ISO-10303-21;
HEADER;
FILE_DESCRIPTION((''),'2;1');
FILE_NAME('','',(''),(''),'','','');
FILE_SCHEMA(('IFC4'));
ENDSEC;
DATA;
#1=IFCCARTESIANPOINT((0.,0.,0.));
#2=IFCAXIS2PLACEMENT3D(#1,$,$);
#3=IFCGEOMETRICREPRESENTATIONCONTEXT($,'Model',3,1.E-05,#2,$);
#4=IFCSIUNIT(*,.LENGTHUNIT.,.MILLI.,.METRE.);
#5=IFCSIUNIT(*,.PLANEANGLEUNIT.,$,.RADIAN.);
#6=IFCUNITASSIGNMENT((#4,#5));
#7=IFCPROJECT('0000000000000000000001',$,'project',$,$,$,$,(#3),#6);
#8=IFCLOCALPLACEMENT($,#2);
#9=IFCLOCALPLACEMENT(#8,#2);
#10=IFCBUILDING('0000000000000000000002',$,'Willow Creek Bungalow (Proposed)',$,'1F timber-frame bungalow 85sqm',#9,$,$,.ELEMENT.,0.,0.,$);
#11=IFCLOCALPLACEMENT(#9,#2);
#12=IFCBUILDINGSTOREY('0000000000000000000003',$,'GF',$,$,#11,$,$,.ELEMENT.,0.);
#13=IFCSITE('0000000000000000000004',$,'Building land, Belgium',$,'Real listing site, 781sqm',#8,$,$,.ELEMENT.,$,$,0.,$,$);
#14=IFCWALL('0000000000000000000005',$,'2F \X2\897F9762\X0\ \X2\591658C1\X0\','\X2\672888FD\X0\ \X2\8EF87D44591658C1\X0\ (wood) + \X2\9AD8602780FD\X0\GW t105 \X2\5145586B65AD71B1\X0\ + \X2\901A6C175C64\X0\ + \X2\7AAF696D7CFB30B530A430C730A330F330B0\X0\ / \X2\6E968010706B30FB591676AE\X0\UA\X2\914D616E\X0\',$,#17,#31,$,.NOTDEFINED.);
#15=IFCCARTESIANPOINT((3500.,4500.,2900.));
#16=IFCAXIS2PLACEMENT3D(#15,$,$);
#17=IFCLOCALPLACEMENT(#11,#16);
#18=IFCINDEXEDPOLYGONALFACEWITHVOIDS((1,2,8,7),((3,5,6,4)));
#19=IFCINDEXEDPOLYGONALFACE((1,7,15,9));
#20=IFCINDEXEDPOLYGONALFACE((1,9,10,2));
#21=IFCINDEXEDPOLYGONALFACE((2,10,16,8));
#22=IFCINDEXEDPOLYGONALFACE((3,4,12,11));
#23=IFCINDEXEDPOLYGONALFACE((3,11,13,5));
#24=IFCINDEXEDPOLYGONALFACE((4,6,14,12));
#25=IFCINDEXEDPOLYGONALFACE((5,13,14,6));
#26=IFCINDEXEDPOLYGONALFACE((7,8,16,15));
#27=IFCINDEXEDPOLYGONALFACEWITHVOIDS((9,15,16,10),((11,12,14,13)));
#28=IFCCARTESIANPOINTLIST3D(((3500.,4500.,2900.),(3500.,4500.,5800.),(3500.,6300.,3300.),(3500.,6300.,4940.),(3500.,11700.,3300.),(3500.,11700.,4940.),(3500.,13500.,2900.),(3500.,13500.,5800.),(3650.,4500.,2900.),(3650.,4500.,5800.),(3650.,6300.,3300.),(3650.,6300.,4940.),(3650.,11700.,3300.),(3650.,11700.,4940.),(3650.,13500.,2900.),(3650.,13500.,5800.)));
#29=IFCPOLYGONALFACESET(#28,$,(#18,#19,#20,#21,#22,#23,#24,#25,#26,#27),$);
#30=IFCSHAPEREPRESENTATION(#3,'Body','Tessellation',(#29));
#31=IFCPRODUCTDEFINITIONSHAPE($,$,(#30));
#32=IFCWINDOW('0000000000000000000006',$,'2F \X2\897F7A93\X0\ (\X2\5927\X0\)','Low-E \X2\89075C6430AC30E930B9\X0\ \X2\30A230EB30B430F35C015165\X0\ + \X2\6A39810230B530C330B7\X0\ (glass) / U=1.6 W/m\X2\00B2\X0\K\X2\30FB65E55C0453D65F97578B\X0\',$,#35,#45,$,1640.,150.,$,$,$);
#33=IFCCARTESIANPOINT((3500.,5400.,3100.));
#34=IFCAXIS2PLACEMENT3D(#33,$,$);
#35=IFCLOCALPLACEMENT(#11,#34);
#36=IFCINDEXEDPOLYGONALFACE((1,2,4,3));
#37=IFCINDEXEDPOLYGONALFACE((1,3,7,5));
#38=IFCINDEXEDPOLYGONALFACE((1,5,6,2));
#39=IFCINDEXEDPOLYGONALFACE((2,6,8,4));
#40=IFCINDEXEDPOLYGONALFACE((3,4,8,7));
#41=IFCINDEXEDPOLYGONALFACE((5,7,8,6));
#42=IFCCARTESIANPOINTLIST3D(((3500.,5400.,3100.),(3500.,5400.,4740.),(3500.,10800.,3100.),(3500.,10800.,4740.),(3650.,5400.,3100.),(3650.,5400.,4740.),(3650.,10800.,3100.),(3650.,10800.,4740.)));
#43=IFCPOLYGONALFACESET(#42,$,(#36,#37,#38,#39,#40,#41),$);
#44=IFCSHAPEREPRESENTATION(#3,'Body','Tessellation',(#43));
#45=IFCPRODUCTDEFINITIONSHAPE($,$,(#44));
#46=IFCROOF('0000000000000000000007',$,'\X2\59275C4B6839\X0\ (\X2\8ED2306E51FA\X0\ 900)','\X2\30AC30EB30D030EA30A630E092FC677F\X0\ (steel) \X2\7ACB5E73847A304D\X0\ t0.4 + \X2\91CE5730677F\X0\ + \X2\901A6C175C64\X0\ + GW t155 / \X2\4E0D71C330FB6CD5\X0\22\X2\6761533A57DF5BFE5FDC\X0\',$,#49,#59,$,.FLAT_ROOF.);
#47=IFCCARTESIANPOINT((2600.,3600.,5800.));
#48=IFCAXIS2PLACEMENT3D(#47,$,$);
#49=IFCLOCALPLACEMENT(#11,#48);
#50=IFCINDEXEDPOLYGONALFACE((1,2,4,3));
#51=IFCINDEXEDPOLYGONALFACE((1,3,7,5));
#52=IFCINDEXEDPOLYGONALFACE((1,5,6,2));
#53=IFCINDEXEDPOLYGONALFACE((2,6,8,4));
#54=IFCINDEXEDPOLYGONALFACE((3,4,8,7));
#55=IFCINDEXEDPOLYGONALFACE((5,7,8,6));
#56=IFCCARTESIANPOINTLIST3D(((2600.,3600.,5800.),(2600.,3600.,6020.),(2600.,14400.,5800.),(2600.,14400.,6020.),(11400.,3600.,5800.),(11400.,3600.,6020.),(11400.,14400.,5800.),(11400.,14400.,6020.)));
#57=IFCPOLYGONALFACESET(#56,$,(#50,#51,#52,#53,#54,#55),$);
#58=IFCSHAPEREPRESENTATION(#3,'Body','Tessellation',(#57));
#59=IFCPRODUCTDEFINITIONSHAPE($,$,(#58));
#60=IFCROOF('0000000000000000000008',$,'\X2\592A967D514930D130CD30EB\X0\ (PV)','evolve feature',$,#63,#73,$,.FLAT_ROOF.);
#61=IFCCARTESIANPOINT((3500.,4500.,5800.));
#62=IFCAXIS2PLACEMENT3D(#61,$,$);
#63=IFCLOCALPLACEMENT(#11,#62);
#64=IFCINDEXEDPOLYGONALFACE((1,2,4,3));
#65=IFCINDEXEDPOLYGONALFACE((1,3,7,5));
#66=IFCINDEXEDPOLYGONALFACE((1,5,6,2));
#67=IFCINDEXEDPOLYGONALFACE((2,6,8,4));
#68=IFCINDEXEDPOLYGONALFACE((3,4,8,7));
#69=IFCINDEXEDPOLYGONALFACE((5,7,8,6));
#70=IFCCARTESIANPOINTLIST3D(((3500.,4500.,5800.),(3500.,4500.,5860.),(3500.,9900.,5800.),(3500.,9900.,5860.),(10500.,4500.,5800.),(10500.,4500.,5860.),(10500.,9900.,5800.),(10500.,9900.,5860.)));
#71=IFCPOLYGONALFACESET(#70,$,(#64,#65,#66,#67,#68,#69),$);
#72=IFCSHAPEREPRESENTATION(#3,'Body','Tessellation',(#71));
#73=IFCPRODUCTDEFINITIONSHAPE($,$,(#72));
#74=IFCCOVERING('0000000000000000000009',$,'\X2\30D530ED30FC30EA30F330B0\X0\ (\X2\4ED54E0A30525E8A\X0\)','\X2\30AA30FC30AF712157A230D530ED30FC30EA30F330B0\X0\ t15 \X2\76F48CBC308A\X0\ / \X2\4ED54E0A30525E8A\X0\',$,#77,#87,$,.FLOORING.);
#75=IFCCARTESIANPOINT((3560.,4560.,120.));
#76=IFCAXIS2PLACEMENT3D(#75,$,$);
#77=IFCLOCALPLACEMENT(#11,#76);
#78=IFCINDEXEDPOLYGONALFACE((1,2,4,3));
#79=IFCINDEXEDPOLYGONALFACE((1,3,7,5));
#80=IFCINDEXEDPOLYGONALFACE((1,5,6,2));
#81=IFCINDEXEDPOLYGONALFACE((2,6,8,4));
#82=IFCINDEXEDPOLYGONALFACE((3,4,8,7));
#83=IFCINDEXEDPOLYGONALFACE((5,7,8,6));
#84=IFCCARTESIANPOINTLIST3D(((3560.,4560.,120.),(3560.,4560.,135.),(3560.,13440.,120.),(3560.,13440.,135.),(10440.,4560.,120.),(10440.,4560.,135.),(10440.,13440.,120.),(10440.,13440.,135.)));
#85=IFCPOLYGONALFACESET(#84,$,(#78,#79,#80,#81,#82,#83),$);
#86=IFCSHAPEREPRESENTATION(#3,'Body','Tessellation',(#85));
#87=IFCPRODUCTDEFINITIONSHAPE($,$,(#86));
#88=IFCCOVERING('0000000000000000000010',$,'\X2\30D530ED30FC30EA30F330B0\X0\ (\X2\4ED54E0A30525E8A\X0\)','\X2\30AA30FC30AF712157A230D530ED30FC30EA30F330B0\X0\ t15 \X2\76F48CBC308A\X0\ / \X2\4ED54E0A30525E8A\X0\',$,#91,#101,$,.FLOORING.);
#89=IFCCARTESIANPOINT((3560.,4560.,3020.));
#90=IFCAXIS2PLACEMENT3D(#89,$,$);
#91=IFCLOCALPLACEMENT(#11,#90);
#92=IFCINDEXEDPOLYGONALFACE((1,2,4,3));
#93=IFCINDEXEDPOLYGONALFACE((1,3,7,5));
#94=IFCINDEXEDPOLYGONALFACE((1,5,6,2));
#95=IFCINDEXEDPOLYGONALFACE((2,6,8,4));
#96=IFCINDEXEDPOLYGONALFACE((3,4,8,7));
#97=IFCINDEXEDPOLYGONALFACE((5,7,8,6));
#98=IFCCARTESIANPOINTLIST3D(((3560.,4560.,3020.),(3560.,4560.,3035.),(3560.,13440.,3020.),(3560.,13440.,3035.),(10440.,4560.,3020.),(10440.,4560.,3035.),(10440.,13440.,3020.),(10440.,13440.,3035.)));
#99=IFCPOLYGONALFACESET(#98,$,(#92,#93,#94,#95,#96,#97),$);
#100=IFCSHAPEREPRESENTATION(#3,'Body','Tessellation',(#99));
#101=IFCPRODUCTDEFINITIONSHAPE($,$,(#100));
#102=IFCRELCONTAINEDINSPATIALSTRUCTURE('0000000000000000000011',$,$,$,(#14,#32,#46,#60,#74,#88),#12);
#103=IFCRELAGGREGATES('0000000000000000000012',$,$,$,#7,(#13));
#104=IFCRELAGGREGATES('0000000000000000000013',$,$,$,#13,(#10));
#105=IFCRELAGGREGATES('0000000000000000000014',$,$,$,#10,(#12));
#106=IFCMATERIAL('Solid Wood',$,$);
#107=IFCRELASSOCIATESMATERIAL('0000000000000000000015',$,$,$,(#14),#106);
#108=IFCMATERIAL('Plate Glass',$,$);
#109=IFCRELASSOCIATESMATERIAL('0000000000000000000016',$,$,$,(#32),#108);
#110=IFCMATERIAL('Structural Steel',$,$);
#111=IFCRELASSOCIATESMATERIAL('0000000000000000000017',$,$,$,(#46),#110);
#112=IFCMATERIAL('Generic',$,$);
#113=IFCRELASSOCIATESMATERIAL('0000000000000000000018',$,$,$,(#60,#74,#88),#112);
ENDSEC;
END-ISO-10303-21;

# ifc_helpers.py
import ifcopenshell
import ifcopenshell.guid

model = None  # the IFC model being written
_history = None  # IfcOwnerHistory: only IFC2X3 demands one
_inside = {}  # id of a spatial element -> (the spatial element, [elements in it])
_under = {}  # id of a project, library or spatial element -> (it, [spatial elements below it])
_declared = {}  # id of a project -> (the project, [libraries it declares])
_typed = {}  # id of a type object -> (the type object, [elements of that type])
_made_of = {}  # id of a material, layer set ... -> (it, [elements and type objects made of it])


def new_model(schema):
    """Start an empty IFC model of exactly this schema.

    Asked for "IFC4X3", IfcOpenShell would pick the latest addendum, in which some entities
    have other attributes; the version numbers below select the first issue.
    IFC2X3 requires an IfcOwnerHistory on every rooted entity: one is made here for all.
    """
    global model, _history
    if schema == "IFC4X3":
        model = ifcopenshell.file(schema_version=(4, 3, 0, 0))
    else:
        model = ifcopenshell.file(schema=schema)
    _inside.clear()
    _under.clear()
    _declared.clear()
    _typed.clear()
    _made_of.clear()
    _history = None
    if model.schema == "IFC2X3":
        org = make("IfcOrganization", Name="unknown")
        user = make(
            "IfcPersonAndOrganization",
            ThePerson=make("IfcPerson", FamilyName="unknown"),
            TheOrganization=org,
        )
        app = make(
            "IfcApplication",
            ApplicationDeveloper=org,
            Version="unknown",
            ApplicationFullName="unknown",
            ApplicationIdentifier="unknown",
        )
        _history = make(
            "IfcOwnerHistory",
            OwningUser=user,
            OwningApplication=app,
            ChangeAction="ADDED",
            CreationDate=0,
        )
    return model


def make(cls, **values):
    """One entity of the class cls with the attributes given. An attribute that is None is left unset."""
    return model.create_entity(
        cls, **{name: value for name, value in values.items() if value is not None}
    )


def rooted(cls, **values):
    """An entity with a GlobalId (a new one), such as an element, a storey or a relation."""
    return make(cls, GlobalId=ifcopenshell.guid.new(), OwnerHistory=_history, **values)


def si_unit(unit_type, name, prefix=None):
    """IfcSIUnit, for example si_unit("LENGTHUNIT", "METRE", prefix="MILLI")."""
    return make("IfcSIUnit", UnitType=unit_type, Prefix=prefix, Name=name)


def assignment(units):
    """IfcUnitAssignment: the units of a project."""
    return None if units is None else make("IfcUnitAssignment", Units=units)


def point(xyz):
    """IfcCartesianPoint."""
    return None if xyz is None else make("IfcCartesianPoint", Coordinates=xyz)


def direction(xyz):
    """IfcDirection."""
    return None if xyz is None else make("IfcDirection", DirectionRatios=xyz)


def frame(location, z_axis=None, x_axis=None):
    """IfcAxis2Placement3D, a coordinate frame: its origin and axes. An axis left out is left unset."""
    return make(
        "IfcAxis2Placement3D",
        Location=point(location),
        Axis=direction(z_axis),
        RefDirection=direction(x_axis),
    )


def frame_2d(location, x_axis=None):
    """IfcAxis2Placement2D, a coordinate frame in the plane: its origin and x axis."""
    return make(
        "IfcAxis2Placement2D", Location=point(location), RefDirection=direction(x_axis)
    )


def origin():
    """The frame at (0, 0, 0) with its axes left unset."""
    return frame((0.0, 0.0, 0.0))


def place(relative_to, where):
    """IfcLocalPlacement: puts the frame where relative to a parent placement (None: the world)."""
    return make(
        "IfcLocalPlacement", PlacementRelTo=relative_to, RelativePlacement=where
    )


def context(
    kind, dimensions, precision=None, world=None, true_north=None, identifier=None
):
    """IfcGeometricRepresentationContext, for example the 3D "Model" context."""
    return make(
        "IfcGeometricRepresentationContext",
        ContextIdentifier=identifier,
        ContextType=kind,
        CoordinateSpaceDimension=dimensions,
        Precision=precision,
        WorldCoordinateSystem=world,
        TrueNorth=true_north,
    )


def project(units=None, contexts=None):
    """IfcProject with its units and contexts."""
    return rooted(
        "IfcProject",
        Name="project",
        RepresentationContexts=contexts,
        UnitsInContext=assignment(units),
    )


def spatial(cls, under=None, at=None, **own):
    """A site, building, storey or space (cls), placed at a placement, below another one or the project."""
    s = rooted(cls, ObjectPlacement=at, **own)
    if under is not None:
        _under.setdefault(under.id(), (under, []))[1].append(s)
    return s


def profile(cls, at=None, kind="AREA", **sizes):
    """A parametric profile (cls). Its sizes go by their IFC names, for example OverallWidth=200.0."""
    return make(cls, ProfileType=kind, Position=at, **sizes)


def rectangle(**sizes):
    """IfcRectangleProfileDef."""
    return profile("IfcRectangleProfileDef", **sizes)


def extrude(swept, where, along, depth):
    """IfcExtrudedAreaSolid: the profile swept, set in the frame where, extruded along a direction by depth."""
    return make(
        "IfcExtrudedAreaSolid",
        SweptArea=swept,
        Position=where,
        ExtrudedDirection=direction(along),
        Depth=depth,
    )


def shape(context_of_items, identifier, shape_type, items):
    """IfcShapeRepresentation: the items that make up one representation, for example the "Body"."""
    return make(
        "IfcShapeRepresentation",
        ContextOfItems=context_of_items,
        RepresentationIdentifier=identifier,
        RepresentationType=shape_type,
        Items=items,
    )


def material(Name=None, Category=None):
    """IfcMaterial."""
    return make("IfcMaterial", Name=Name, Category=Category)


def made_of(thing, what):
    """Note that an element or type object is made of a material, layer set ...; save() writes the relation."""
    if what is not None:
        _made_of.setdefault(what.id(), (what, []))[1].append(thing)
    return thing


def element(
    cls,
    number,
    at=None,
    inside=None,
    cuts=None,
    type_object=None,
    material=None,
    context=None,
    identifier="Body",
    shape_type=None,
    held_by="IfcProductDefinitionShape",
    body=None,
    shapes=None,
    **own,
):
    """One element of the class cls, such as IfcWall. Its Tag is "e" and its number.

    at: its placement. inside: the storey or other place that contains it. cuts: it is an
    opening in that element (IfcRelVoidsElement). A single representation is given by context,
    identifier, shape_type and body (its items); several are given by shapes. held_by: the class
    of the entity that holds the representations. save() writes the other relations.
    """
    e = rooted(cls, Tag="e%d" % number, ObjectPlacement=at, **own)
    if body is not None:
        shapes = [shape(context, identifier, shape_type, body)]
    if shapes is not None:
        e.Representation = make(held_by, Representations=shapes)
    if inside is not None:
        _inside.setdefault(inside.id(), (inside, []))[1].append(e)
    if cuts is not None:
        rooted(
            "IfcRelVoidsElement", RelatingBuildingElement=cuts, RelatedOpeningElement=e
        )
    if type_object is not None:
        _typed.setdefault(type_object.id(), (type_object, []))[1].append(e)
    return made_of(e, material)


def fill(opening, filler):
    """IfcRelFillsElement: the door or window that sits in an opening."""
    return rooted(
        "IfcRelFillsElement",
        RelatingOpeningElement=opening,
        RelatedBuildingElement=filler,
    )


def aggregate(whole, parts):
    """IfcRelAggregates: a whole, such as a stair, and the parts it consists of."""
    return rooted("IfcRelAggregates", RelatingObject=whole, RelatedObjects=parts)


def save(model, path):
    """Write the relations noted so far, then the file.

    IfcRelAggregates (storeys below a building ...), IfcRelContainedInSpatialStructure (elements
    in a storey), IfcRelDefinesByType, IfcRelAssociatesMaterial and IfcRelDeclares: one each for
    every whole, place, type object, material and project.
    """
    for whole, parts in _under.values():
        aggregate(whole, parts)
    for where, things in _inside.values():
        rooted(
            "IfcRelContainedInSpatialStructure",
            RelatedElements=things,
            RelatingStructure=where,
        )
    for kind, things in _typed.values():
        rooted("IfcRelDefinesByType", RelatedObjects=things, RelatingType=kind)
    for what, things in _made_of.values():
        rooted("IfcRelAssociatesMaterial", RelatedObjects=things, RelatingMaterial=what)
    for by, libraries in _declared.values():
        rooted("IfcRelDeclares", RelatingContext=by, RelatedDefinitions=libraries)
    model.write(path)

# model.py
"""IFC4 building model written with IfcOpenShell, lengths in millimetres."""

from ifc_helpers import new_model, si_unit, frame, frame_2d, origin, place, context, project, spatial, rectangle, extrude, material, element, fill, save


model = new_model("IFC4")

# Units and contexts
model_context = context("Model", 3, precision=1e-05, world=origin())
ifc_project = project(units=[si_unit("LENGTHUNIT", "METRE", prefix="MILLI"), si_unit("PLANEANGLEUNIT", "RADIAN")], contexts=[model_context])

# Site, building, storey
site_placement = place(None, origin())
site = spatial("IfcSite", under=ifc_project, at=site_placement, Name="Building land, Belgium", ObjectType="Real listing site, 781sqm", CompositionType="ELEMENT", RefElevation=0.0)
building_placement = place(site_placement, origin())
building = spatial("IfcBuilding", under=site, at=building_placement, Name="Willow Creek Bungalow (Proposed)", ObjectType="1F timber-frame bungalow 85sqm", CompositionType="ELEMENT", ElevationOfRefHeight=0.0, ElevationOfTerrain=0.0)
storey_placement = place(building_placement, origin())
storey = spatial("IfcBuildingStorey", under=building, at=storey_placement, Name="GF", CompositionType="ELEMENT", Elevation=0.0)

# Shared definitions
ifc_material_1 = material(Name="Solid Wood")
ifc_material_2 = material(Name="Generic")

# Shared definitions
ifc_material_3 = material(Name="Plate Glass")

# Wall, opening, window
wall_1_placement = place(storey_placement, frame((3500.0, 4500.0, 2900.0)))
wall_1 = element("IfcWall", 1, at=wall_1_placement, inside=storey, material=ifc_material_1, Name="2F 西面 外壁", Description="木製 軸組外壁 (wood) + 高性能GW t105 充填断熱 + 通気層 + 窯業系サイディング / 準耐火・外皮UA配慮", PredefinedType="NOTDEFINED", context=model_context, shape_type="SweptSolid", body=[
    extrude(rectangle(XDim=150.0, YDim=9000.0, at=frame_2d((75.0, 4500.0))), frame((3500.0, 4500.0, 2900.0)), (0.0, 0.0, 1.0), 2900.0),
])
opening_1_placement = place(storey_placement, frame((3500.0, 5400.0, 3100.0)))
opening_1 = element("IfcOpeningElement", 2, at=opening_1_placement, cuts=wall_1, PredefinedType="NOTDEFINED", context=model_context, shape_type="SweptSolid", body=[
    extrude(rectangle(XDim=150.0, YDim=5400.0, at=frame_2d((75.0, 2700.0))), frame((3500.0, 5400.0, 3100.0)), (0.0, 0.0, 1.0), 1640.0),
])
window_1_placement = place(storey_placement, frame((3500.0, 5400.0, 3100.0)))
window_1 = element("IfcWindow", 3, at=window_1_placement, inside=storey, material=ifc_material_3, Name="2F 西窓 (大)", Description="Low-E 複層ガラス アルゴン封入 + 樹脂サッシ (glass) / U=1.6 W/m²K・日射取得型", OverallHeight=1640.0, OverallWidth=150.0, context=model_context, shape_type="SweptSolid", body=[
    extrude(rectangle(XDim=150.0, YDim=5400.0, at=frame_2d((75.0, 2700.0))), frame((3500.0, 5400.0, 3100.0)), (0.0, 0.0, 1.0), 1640.0),
])
fill(opening_1, window_1)

# Roofs
ifc_material_4 = material(Name="Structural Steel")
roof_1_placement = place(storey_placement, frame((2600.0, 3600.0, 5800.0)))
element("IfcRoof", 4, at=roof_1_placement, inside=storey, material=ifc_material_4, Name="大屋根 (軒の出 900)", Description="ガルバリウム鋼板 (steel) 立平葺き t0.4 + 野地板 + 通気層 + GW t155 / 不燃・法22条区域対応", PredefinedType="FLAT_ROOF", context=model_context, shape_type="SweptSolid", body=[
    extrude(rectangle(XDim=8800.0, YDim=10800.0, at=frame_2d((4400.0, 5400.0))), frame((2600.0, 3600.0, 5800.0)), (0.0, 0.0, 1.0), 220.0),
])
roof_2_placement = place(storey_placement, frame((3500.0, 4500.0, 5800.0)))
element("IfcRoof", 5, at=roof_2_placement, inside=storey, material=ifc_material_2, Name="太陽光パネル (PV)", Description="evolve feature", PredefinedType="FLAT_ROOF", context=model_context, shape_type="SweptSolid", body=[
    extrude(rectangle(XDim=7000.0, YDim=5400.0, at=frame_2d((3500.0, 2700.0))), frame((3500.0, 4500.0, 5800.0)), (0.0, 0.0, 1.0), 60.0),
])

# Coverings
covering_1_placement = place(storey_placement, frame((3560.0, 4560.0, 120.0)))
element("IfcCovering", 6, at=covering_1_placement, inside=storey, material=ifc_material_2, Name="フローリング (仕上げ床)", Description="オーク無垢フローリング t15 直貼り / 仕上げ床", PredefinedType="FLOORING", context=model_context, shape_type="SweptSolid", body=[
    extrude(rectangle(XDim=6880.0, YDim=8880.0, at=frame_2d((3440.0, 4440.0))), frame((3560.0, 4560.0, 120.0)), (0.0, 0.0, 1.0), 15.0),
])
covering_2_placement = place(storey_placement, frame((3560.0, 4560.0, 3020.0)))
element("IfcCovering", 7, at=covering_2_placement, inside=storey, material=ifc_material_2, Name="フローリング (仕上げ床)", Description="オーク無垢フローリング t15 直貼り / 仕上げ床", PredefinedType="FLOORING", context=model_context, shape_type="SweptSolid", body=[
    extrude(rectangle(XDim=6880.0, YDim=8880.0, at=frame_2d((3440.0, 4440.0))), frame((3560.0, 4560.0, 3020.0)), (0.0, 0.0, 1.0), 15.0),
])

save(model, "model.ifc")
